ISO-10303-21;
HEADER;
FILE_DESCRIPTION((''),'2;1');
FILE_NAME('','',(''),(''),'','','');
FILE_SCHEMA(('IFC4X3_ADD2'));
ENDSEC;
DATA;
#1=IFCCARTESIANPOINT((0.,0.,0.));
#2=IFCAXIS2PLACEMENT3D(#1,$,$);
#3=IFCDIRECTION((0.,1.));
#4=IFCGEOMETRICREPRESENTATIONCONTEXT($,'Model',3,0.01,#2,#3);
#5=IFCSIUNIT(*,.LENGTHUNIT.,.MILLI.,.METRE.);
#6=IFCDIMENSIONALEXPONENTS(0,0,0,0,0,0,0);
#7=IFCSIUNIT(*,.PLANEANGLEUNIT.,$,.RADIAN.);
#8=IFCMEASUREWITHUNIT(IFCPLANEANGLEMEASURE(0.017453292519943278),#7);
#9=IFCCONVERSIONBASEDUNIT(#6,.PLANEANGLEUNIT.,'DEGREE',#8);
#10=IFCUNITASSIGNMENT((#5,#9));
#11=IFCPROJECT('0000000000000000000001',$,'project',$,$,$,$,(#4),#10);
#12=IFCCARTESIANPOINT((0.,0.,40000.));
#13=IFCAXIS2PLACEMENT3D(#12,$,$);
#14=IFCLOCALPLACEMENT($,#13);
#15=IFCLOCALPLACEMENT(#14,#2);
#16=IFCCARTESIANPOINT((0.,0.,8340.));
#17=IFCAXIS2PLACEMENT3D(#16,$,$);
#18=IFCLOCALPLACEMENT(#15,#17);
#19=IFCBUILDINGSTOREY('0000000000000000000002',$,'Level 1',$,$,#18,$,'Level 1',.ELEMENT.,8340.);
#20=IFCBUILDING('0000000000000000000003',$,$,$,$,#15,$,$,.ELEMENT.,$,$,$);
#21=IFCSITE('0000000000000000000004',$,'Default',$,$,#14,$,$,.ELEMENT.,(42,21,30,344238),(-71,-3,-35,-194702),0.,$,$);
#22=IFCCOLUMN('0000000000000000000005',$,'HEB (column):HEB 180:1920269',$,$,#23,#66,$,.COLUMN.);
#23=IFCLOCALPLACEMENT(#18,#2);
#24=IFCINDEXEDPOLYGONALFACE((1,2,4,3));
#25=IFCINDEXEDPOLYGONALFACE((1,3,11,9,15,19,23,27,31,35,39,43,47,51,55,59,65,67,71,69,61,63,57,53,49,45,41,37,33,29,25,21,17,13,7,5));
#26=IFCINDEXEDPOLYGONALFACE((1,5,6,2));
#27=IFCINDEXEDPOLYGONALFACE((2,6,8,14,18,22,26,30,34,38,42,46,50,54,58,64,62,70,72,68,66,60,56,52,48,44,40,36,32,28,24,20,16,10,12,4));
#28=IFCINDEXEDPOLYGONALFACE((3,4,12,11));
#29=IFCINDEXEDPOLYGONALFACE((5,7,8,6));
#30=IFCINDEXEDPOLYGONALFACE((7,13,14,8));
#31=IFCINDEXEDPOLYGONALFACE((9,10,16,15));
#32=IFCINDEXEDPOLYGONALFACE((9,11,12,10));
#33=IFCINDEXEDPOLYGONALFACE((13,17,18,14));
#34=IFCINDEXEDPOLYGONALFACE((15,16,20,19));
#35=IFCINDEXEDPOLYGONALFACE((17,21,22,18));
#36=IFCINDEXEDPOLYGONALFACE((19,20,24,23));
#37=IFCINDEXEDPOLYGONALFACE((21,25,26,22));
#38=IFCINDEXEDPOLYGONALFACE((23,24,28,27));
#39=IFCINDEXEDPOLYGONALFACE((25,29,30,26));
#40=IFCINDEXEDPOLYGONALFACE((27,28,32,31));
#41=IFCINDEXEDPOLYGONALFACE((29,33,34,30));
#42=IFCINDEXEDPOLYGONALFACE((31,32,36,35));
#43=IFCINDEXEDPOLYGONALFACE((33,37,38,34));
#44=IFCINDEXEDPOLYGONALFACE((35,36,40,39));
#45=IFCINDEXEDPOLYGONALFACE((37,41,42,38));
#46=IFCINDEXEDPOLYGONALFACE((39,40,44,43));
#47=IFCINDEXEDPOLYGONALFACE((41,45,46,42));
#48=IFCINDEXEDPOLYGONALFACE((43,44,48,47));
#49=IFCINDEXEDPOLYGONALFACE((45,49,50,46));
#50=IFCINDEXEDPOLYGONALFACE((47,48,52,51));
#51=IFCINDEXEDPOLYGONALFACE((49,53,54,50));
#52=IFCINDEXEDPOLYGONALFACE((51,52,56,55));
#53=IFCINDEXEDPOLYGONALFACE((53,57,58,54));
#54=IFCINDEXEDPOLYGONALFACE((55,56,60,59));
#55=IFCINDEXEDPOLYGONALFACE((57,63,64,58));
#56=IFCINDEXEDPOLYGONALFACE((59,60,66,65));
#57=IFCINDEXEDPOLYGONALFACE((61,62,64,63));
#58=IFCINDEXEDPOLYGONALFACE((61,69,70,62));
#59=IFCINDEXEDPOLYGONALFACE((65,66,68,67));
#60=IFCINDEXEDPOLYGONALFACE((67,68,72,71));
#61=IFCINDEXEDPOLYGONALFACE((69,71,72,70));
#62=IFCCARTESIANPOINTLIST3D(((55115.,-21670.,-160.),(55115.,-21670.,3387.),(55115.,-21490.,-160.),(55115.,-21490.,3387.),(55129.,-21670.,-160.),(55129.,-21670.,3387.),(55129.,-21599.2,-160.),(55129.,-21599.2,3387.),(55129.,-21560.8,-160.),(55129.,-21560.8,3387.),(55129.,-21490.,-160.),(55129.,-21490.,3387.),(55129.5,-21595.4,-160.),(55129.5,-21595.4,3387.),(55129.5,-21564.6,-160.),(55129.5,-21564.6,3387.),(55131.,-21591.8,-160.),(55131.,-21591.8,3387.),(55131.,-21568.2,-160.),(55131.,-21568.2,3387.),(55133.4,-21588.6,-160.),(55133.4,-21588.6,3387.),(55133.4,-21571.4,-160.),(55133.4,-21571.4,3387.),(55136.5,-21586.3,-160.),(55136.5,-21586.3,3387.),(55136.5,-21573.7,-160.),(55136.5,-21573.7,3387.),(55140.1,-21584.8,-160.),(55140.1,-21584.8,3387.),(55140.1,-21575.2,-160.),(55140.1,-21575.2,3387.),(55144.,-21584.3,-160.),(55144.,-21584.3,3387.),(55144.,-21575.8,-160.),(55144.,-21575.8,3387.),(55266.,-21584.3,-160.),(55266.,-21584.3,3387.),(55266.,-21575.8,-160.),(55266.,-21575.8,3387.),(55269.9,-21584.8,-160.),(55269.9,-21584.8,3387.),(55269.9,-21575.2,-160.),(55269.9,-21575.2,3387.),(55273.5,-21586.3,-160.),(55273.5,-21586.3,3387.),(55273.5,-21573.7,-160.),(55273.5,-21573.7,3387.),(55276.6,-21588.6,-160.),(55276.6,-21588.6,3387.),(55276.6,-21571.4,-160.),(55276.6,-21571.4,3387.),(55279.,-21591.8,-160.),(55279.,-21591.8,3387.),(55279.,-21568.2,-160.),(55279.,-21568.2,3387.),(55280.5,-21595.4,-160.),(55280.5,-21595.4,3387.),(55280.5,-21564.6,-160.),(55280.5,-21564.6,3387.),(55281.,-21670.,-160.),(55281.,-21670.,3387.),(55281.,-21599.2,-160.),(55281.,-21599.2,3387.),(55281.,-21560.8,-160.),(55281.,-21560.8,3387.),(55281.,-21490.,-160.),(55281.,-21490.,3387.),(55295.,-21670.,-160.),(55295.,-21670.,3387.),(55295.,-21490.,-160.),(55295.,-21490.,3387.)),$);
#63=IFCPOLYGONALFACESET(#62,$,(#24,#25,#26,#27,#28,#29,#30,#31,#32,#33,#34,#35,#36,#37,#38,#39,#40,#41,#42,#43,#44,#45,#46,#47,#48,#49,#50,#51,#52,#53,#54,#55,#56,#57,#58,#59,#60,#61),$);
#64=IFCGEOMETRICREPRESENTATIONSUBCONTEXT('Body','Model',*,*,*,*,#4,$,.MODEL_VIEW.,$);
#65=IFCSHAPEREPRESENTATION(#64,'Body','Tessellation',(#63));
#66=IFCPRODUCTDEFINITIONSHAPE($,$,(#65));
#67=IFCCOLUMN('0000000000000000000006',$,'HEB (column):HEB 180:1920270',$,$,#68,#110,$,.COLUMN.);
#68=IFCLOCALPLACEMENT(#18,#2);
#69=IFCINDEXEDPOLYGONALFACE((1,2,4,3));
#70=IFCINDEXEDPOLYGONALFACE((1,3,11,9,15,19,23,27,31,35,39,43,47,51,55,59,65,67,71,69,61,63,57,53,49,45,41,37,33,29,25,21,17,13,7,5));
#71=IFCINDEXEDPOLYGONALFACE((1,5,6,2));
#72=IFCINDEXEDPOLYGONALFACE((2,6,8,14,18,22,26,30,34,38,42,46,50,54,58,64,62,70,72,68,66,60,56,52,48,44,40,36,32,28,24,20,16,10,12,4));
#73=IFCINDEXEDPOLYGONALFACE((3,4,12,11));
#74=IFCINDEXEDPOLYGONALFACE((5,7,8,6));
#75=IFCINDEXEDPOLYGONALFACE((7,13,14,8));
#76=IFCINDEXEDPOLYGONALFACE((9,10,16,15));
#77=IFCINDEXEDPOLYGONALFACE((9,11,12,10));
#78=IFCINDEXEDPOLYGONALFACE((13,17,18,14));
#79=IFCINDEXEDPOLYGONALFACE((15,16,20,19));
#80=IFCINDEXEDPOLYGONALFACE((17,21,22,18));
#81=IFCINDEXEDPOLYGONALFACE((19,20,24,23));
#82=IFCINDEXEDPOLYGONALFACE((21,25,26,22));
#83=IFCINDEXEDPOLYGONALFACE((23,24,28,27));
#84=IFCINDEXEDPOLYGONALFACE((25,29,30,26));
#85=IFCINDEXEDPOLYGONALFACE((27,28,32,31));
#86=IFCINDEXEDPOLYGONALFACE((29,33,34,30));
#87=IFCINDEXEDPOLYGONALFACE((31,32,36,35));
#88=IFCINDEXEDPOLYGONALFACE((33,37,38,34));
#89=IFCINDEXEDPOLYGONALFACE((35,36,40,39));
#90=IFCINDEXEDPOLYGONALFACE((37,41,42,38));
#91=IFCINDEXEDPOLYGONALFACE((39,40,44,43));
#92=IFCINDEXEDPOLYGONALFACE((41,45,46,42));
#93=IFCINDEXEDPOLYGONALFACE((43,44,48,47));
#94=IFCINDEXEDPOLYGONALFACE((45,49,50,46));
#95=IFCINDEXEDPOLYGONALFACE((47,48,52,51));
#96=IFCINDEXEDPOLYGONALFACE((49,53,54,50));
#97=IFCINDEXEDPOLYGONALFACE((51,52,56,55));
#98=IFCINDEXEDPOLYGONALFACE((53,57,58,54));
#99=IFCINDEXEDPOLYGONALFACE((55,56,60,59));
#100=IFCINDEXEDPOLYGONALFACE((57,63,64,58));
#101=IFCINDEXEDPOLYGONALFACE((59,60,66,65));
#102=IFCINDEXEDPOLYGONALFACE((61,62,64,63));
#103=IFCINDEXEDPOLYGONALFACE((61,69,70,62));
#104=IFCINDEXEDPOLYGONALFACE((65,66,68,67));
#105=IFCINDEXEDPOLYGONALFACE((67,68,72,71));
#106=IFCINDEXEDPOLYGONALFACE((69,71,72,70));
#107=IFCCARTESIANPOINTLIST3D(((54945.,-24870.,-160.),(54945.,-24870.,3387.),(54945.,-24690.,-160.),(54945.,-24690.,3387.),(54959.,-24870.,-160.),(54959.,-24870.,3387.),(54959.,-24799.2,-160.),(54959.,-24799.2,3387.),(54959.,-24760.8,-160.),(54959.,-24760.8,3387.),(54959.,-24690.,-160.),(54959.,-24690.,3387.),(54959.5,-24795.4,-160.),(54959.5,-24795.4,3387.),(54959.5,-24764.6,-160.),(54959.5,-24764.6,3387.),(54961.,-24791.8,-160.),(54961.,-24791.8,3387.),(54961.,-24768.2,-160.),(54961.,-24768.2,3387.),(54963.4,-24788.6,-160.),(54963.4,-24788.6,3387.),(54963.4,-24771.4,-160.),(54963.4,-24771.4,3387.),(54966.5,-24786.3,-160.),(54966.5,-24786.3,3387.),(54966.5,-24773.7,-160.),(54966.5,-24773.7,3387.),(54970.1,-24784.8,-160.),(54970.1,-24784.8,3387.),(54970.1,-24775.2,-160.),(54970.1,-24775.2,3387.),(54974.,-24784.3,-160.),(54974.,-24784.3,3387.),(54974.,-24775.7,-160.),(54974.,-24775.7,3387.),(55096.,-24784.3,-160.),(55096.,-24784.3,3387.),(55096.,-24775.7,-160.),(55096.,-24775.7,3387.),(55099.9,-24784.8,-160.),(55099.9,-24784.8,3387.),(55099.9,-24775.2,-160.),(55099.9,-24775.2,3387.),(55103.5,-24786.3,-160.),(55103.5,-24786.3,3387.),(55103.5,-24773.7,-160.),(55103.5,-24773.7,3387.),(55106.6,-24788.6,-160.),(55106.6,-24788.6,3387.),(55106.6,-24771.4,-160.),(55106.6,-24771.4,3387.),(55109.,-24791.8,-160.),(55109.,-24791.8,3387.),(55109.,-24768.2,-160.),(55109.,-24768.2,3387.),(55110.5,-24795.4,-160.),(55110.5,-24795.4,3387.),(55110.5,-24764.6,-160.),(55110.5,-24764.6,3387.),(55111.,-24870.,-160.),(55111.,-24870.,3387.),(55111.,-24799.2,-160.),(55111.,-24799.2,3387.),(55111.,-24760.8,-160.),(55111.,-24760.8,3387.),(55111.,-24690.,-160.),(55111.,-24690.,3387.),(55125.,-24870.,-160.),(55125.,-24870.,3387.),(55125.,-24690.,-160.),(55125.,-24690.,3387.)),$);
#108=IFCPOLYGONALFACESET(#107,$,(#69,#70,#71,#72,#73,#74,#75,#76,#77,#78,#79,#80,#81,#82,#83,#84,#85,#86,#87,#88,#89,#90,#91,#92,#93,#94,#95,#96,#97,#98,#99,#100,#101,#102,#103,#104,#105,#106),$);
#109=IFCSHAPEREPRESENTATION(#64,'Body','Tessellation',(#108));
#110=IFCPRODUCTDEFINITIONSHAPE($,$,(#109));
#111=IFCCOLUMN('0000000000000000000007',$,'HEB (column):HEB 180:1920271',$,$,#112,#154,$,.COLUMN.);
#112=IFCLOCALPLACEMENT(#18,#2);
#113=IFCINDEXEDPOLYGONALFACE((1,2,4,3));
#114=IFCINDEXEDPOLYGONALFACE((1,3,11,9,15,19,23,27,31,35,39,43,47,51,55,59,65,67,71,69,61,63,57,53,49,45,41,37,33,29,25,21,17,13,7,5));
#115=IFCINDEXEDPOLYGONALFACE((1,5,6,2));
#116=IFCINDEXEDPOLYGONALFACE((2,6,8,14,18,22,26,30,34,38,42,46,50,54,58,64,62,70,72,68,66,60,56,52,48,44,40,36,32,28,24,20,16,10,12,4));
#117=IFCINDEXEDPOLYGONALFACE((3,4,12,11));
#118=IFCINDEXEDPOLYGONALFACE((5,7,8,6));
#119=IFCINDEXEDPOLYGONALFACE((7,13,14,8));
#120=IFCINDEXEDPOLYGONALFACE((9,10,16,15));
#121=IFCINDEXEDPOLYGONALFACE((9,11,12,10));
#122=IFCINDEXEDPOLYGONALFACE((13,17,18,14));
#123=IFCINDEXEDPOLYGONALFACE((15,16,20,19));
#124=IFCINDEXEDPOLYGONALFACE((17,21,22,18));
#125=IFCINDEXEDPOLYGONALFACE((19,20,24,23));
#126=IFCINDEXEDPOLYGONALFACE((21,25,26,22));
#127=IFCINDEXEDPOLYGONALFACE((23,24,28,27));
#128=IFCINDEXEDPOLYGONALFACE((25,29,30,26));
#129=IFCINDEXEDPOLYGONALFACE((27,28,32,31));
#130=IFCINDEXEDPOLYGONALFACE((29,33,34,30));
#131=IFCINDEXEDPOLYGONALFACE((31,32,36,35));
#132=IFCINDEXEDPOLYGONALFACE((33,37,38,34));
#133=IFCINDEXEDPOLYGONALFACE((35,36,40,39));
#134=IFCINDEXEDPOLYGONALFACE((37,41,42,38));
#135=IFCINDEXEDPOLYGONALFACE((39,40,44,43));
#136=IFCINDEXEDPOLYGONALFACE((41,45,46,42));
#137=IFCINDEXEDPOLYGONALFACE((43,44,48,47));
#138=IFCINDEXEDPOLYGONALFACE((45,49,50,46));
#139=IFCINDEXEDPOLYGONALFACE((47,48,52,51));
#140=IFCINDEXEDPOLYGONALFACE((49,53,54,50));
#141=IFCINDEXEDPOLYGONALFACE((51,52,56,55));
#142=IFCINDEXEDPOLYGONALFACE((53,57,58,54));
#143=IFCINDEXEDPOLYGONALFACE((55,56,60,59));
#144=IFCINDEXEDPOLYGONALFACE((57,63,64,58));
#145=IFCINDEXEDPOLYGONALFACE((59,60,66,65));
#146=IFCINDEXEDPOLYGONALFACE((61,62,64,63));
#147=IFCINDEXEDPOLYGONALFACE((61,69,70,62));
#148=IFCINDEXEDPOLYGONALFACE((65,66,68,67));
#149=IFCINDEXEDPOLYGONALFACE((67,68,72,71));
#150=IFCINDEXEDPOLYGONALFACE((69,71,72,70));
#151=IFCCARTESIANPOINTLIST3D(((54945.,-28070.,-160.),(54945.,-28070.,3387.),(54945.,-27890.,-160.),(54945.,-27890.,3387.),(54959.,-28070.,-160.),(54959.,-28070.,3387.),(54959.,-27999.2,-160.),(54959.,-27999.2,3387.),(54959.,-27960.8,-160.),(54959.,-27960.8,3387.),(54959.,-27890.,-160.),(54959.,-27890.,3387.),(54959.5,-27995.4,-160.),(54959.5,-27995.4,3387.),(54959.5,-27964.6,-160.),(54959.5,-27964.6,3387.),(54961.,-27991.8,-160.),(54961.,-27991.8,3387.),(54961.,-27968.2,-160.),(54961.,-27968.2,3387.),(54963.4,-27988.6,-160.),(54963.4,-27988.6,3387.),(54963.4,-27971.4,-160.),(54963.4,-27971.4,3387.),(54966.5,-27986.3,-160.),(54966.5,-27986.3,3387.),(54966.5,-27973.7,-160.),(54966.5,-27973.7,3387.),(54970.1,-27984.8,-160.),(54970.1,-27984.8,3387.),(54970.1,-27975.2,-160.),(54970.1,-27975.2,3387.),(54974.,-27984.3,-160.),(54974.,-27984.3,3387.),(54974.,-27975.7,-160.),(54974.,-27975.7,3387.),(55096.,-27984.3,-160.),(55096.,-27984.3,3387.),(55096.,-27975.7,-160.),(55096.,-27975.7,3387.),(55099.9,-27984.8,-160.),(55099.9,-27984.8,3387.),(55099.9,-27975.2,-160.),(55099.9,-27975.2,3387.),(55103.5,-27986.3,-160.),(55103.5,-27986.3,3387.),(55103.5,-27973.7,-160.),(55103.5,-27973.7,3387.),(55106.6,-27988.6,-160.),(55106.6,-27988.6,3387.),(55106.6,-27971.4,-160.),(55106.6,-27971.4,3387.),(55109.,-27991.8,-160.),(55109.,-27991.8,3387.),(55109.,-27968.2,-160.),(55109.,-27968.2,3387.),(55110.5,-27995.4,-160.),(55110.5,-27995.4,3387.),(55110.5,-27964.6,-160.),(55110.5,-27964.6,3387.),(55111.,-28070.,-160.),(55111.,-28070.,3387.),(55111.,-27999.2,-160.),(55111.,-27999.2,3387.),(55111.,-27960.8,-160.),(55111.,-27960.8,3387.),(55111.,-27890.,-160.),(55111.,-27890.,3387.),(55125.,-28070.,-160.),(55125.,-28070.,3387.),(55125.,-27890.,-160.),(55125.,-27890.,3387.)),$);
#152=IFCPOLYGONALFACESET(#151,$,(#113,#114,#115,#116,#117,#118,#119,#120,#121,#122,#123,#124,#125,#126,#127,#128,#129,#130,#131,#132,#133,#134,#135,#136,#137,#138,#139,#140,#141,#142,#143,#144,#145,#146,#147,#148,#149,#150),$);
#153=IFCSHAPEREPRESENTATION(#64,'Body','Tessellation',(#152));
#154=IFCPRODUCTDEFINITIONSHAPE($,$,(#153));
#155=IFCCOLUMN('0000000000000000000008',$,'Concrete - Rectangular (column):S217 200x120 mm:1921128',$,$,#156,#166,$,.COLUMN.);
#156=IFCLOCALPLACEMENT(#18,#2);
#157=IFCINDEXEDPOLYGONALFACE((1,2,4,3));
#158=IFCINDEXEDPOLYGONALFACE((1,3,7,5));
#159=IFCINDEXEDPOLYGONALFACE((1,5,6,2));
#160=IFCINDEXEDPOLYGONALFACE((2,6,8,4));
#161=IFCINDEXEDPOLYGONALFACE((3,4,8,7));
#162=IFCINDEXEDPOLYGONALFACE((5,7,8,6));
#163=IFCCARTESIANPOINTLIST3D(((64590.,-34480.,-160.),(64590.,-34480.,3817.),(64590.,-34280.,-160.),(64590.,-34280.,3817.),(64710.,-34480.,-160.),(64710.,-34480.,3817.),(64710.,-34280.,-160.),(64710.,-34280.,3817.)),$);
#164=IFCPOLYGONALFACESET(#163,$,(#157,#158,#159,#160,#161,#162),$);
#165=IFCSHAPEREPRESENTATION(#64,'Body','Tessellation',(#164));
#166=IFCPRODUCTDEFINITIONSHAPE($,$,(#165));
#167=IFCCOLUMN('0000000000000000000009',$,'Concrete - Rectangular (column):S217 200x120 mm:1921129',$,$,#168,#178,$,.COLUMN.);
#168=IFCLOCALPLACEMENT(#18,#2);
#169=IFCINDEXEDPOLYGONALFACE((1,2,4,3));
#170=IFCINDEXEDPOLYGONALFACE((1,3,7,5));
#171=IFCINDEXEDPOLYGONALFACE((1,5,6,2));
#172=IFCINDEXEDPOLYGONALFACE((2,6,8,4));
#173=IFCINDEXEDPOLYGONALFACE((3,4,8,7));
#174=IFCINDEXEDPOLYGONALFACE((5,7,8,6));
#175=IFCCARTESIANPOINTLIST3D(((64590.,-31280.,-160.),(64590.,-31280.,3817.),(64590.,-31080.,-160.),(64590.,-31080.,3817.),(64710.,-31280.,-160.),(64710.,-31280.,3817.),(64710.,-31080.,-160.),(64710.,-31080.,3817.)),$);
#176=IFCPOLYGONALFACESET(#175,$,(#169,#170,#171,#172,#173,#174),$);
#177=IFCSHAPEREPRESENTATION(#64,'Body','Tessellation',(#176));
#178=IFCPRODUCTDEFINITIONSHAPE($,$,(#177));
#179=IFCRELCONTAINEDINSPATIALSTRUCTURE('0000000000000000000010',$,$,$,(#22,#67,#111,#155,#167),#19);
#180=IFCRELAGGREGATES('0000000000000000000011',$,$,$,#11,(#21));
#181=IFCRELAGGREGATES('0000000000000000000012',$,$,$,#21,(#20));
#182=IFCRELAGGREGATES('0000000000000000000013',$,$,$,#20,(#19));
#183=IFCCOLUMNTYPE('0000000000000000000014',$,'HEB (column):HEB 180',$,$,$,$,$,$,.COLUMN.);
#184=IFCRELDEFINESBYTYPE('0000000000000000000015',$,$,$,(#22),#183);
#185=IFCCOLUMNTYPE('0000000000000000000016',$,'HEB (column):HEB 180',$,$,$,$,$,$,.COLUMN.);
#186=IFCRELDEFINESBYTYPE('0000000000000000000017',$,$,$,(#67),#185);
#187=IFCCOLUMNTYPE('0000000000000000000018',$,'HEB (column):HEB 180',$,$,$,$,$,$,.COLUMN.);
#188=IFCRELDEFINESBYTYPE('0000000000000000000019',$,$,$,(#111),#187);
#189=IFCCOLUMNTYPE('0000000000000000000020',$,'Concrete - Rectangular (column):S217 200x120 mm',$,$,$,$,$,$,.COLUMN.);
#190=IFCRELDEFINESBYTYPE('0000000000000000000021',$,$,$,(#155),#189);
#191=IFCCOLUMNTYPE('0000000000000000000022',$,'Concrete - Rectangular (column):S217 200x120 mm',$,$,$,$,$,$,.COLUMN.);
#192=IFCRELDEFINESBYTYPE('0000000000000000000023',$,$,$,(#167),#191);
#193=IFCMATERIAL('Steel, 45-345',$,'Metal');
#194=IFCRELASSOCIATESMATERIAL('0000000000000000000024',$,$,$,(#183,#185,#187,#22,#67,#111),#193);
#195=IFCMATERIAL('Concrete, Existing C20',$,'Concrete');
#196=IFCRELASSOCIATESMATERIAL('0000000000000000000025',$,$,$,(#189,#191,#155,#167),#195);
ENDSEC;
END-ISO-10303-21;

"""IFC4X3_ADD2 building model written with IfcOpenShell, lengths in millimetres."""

from ifc_helpers import new_model, entity, si_unit, converted_unit, direction, frame, frame_2d, origin, origin_2d_with_axis, place, context, subcontext, project, spatial, rectangle, i_section, extrude, source, transform, mapped, material, material_profile, profile_set, profile_usage, type_object, type_shapes, element, save


model = new_model("IFC4X3_ADD2")

# Units and contexts
model_context = context("Model", 3, precision=0.01, world=origin(), true_north=direction((0.0, 1.0)))
body_context = subcontext(model_context, "Body", "Model", "MODEL_VIEW")
ifc_project = project(units=[si_unit("LENGTHUNIT", "METRE", prefix="MILLI"), converted_unit("PLANEANGLEUNIT", "DEGREE", entity("IfcPlaneAngleMeasure", 0.017453292519943278), si_unit("PLANEANGLEUNIT", "RADIAN"), dimensions=[0, 0, 0, 0, 0, 0, 0])], contexts=[model_context])

# Site, building, storey
site_placement = place(None, frame((0.0, 0.0, 40000.0)))
site = spatial("IfcSite", under=ifc_project, at=site_placement, Name="Default", CompositionType="ELEMENT", RefLatitude=(42, 21, 30, 344238), RefLongitude=(-71, -3, -35, -194702), RefElevation=0.0)
building_placement = place(site_placement, origin())
building = spatial("IfcBuilding", under=site, at=building_placement, CompositionType="ELEMENT")
storey_placement = place(building_placement, frame((0.0, 0.0, 8340.0)))
storey = spatial("IfcBuildingStorey", under=building, at=storey_placement, Name="Level 1", LongName="Level 1", CompositionType="ELEMENT", Elevation=8340.0)

# Columns
ifc_material_1 = material(Name="Steel, 45-345", Category="Metal")
ifc_material_profile_1 = material_profile(ifc_material_1, i_section(OverallWidth=180.0, OverallDepth=180.0, WebThickness=8.5, FlangeThickness=14.0, FilletRadius=15.0, at=origin_2d_with_axis()), Name="HEB 180")
ifc_profile_set_1 = profile_set([ifc_material_profile_1], Name="HEB 180")
ifc_profile_usage_1 = profile_usage(ifc_profile_set_1)
column_type_1 = type_object("IfcColumnType", Name="HEB (column):HEB 180", PredefinedType="COLUMN", material=ifc_profile_set_1)
shared_shape_1 = source(origin(), body_context, "Body", "SweptSolid", [
    extrude(i_section(OverallWidth=180.0, OverallDepth=180.0, WebThickness=8.5, FlangeThickness=14.0, FilletRadius=15.0, at=frame_2d((0.0, 0.0), x_axis=(1.0, 0.0))), frame((55205.0, -21580.0, 8180.0), z_axis=(0.0, 0.0, 1.0), x_axis=(0.0, 1.0, 0.0)), (0.0, 0.0, 1.0), 3547.0),
])
type_shapes(column_type_1, [shared_shape_1])
column_1_placement = place(storey_placement, frame((0.0, 0.0, -8340.0)))
element("IfcColumn", 1, at=column_1_placement, inside=storey, type_object=column_type_1, material=ifc_profile_usage_1, Name="HEB (column):HEB 180:1920269", PredefinedType="COLUMN", context=body_context, shape_type="MappedRepresentation", body=[
    mapped(shared_shape_1, transform((0.0, 0.0, 0.0), scale=1.0)),
])
column_type_2 = type_object("IfcColumnType", Name="HEB (column):HEB 180", PredefinedType="COLUMN", material=ifc_profile_set_1)
shared_shape_2 = source(origin(), body_context, "Body", "SweptSolid", [
    extrude(i_section(OverallWidth=180.0, OverallDepth=180.0, WebThickness=8.5, FlangeThickness=14.0, FilletRadius=15.0, at=frame_2d((0.0, 0.0), x_axis=(1.0, 0.0))), frame((55035.0, -24780.0, 8180.0), z_axis=(0.0, 0.0, 1.0), x_axis=(0.0, 1.0, 0.0)), (0.0, 0.0, 1.0), 3547.0),
])
type_shapes(column_type_2, [shared_shape_2])
column_2_placement = place(storey_placement, frame((0.0, 0.0, -8340.0)))
element("IfcColumn", 2, at=column_2_placement, inside=storey, type_object=column_type_2, material=ifc_profile_usage_1, Name="HEB (column):HEB 180:1920270", PredefinedType="COLUMN", context=body_context, shape_type="MappedRepresentation", body=[
    mapped(shared_shape_2, transform((0.0, 0.0, 0.0), scale=1.0)),
])
column_type_3 = type_object("IfcColumnType", Name="HEB (column):HEB 180", PredefinedType="COLUMN", material=ifc_profile_set_1)
shared_shape_3 = source(origin(), body_context, "Body", "SweptSolid", [
    extrude(i_section(OverallWidth=180.0, OverallDepth=180.0, WebThickness=8.5, FlangeThickness=14.0, FilletRadius=15.0, at=frame_2d((0.0, 0.0), x_axis=(1.0, 0.0))), frame((55035.0, -27980.0, 8180.0), z_axis=(0.0, 0.0, 1.0), x_axis=(0.0, 1.0, 0.0)), (0.0, 0.0, 1.0), 3547.0),
])
type_shapes(column_type_3, [shared_shape_3])
column_3_placement = place(storey_placement, frame((0.0, 0.0, -8340.0)))
element("IfcColumn", 3, at=column_3_placement, inside=storey, type_object=column_type_3, material=ifc_profile_usage_1, Name="HEB (column):HEB 180:1920271", PredefinedType="COLUMN", context=body_context, shape_type="MappedRepresentation", body=[
    mapped(shared_shape_3, transform((0.0, 0.0, 0.0), scale=1.0)),
])
ifc_material_2 = material(Name="Concrete, Existing C20", Category="Concrete")
ifc_material_profile_2 = material_profile(ifc_material_2, rectangle(XDim=200.0, YDim=120.0, at=frame_2d((0.0, 0.0), x_axis=(1.0, 0.0))), Name="S217 200x120 mm")
ifc_profile_set_2 = profile_set([ifc_material_profile_2], Name="S217 200x120 mm")
ifc_profile_usage_2 = profile_usage(ifc_profile_set_2)
column_type_4 = type_object("IfcColumnType", Name="Concrete - Rectangular (column):S217 200x120 mm", PredefinedType="COLUMN", material=ifc_profile_set_2)
shared_shape_4 = source(origin(), body_context, "Body", "SweptSolid", [
    extrude(rectangle(XDim=200.0, YDim=120.0, at=frame_2d((0.0, 0.0), x_axis=(1.0, 0.0))), frame((64650.0, -34380.0, 8180.0), z_axis=(0.0, 0.0, 1.0), x_axis=(0.0, 1.0, 0.0)), (0.0, 0.0, 1.0), 3977.0),
])
type_shapes(column_type_4, [shared_shape_4])
column_4_placement = place(storey_placement, frame((0.0, 0.0, -8340.0)))
element("IfcColumn", 4, at=column_4_placement, inside=storey, type_object=column_type_4, material=ifc_profile_usage_2, Name="Concrete - Rectangular (column):S217 200x120 mm:1921128", PredefinedType="COLUMN", context=body_context, shape_type="MappedRepresentation", body=[
    mapped(shared_shape_4, transform((0.0, 0.0, 0.0), scale=1.0)),
])
column_type_5 = type_object("IfcColumnType", Name="Concrete - Rectangular (column):S217 200x120 mm", PredefinedType="COLUMN", material=ifc_profile_set_2)
shared_shape_5 = source(origin(), body_context, "Body", "SweptSolid", [
    extrude(rectangle(XDim=200.0, YDim=120.0, at=frame_2d((0.0, 0.0), x_axis=(1.0, 0.0))), frame((64650.0, -31180.0, 8180.0), z_axis=(0.0, 0.0, 1.0), x_axis=(0.0, 1.0, 0.0)), (0.0, 0.0, 1.0), 3977.0),
])
type_shapes(column_type_5, [shared_shape_5])
column_5_placement = place(storey_placement, frame((0.0, 0.0, -8340.0)))
element("IfcColumn", 5, at=column_5_placement, inside=storey, type_object=column_type_5, material=ifc_profile_usage_2, Name="Concrete - Rectangular (column):S217 200x120 mm:1921129", PredefinedType="COLUMN", context=body_context, shape_type="MappedRepresentation", body=[
    mapped(shared_shape_5, transform((0.0, 0.0, 0.0), scale=1.0)),
])

save(model, "model.ifc")
